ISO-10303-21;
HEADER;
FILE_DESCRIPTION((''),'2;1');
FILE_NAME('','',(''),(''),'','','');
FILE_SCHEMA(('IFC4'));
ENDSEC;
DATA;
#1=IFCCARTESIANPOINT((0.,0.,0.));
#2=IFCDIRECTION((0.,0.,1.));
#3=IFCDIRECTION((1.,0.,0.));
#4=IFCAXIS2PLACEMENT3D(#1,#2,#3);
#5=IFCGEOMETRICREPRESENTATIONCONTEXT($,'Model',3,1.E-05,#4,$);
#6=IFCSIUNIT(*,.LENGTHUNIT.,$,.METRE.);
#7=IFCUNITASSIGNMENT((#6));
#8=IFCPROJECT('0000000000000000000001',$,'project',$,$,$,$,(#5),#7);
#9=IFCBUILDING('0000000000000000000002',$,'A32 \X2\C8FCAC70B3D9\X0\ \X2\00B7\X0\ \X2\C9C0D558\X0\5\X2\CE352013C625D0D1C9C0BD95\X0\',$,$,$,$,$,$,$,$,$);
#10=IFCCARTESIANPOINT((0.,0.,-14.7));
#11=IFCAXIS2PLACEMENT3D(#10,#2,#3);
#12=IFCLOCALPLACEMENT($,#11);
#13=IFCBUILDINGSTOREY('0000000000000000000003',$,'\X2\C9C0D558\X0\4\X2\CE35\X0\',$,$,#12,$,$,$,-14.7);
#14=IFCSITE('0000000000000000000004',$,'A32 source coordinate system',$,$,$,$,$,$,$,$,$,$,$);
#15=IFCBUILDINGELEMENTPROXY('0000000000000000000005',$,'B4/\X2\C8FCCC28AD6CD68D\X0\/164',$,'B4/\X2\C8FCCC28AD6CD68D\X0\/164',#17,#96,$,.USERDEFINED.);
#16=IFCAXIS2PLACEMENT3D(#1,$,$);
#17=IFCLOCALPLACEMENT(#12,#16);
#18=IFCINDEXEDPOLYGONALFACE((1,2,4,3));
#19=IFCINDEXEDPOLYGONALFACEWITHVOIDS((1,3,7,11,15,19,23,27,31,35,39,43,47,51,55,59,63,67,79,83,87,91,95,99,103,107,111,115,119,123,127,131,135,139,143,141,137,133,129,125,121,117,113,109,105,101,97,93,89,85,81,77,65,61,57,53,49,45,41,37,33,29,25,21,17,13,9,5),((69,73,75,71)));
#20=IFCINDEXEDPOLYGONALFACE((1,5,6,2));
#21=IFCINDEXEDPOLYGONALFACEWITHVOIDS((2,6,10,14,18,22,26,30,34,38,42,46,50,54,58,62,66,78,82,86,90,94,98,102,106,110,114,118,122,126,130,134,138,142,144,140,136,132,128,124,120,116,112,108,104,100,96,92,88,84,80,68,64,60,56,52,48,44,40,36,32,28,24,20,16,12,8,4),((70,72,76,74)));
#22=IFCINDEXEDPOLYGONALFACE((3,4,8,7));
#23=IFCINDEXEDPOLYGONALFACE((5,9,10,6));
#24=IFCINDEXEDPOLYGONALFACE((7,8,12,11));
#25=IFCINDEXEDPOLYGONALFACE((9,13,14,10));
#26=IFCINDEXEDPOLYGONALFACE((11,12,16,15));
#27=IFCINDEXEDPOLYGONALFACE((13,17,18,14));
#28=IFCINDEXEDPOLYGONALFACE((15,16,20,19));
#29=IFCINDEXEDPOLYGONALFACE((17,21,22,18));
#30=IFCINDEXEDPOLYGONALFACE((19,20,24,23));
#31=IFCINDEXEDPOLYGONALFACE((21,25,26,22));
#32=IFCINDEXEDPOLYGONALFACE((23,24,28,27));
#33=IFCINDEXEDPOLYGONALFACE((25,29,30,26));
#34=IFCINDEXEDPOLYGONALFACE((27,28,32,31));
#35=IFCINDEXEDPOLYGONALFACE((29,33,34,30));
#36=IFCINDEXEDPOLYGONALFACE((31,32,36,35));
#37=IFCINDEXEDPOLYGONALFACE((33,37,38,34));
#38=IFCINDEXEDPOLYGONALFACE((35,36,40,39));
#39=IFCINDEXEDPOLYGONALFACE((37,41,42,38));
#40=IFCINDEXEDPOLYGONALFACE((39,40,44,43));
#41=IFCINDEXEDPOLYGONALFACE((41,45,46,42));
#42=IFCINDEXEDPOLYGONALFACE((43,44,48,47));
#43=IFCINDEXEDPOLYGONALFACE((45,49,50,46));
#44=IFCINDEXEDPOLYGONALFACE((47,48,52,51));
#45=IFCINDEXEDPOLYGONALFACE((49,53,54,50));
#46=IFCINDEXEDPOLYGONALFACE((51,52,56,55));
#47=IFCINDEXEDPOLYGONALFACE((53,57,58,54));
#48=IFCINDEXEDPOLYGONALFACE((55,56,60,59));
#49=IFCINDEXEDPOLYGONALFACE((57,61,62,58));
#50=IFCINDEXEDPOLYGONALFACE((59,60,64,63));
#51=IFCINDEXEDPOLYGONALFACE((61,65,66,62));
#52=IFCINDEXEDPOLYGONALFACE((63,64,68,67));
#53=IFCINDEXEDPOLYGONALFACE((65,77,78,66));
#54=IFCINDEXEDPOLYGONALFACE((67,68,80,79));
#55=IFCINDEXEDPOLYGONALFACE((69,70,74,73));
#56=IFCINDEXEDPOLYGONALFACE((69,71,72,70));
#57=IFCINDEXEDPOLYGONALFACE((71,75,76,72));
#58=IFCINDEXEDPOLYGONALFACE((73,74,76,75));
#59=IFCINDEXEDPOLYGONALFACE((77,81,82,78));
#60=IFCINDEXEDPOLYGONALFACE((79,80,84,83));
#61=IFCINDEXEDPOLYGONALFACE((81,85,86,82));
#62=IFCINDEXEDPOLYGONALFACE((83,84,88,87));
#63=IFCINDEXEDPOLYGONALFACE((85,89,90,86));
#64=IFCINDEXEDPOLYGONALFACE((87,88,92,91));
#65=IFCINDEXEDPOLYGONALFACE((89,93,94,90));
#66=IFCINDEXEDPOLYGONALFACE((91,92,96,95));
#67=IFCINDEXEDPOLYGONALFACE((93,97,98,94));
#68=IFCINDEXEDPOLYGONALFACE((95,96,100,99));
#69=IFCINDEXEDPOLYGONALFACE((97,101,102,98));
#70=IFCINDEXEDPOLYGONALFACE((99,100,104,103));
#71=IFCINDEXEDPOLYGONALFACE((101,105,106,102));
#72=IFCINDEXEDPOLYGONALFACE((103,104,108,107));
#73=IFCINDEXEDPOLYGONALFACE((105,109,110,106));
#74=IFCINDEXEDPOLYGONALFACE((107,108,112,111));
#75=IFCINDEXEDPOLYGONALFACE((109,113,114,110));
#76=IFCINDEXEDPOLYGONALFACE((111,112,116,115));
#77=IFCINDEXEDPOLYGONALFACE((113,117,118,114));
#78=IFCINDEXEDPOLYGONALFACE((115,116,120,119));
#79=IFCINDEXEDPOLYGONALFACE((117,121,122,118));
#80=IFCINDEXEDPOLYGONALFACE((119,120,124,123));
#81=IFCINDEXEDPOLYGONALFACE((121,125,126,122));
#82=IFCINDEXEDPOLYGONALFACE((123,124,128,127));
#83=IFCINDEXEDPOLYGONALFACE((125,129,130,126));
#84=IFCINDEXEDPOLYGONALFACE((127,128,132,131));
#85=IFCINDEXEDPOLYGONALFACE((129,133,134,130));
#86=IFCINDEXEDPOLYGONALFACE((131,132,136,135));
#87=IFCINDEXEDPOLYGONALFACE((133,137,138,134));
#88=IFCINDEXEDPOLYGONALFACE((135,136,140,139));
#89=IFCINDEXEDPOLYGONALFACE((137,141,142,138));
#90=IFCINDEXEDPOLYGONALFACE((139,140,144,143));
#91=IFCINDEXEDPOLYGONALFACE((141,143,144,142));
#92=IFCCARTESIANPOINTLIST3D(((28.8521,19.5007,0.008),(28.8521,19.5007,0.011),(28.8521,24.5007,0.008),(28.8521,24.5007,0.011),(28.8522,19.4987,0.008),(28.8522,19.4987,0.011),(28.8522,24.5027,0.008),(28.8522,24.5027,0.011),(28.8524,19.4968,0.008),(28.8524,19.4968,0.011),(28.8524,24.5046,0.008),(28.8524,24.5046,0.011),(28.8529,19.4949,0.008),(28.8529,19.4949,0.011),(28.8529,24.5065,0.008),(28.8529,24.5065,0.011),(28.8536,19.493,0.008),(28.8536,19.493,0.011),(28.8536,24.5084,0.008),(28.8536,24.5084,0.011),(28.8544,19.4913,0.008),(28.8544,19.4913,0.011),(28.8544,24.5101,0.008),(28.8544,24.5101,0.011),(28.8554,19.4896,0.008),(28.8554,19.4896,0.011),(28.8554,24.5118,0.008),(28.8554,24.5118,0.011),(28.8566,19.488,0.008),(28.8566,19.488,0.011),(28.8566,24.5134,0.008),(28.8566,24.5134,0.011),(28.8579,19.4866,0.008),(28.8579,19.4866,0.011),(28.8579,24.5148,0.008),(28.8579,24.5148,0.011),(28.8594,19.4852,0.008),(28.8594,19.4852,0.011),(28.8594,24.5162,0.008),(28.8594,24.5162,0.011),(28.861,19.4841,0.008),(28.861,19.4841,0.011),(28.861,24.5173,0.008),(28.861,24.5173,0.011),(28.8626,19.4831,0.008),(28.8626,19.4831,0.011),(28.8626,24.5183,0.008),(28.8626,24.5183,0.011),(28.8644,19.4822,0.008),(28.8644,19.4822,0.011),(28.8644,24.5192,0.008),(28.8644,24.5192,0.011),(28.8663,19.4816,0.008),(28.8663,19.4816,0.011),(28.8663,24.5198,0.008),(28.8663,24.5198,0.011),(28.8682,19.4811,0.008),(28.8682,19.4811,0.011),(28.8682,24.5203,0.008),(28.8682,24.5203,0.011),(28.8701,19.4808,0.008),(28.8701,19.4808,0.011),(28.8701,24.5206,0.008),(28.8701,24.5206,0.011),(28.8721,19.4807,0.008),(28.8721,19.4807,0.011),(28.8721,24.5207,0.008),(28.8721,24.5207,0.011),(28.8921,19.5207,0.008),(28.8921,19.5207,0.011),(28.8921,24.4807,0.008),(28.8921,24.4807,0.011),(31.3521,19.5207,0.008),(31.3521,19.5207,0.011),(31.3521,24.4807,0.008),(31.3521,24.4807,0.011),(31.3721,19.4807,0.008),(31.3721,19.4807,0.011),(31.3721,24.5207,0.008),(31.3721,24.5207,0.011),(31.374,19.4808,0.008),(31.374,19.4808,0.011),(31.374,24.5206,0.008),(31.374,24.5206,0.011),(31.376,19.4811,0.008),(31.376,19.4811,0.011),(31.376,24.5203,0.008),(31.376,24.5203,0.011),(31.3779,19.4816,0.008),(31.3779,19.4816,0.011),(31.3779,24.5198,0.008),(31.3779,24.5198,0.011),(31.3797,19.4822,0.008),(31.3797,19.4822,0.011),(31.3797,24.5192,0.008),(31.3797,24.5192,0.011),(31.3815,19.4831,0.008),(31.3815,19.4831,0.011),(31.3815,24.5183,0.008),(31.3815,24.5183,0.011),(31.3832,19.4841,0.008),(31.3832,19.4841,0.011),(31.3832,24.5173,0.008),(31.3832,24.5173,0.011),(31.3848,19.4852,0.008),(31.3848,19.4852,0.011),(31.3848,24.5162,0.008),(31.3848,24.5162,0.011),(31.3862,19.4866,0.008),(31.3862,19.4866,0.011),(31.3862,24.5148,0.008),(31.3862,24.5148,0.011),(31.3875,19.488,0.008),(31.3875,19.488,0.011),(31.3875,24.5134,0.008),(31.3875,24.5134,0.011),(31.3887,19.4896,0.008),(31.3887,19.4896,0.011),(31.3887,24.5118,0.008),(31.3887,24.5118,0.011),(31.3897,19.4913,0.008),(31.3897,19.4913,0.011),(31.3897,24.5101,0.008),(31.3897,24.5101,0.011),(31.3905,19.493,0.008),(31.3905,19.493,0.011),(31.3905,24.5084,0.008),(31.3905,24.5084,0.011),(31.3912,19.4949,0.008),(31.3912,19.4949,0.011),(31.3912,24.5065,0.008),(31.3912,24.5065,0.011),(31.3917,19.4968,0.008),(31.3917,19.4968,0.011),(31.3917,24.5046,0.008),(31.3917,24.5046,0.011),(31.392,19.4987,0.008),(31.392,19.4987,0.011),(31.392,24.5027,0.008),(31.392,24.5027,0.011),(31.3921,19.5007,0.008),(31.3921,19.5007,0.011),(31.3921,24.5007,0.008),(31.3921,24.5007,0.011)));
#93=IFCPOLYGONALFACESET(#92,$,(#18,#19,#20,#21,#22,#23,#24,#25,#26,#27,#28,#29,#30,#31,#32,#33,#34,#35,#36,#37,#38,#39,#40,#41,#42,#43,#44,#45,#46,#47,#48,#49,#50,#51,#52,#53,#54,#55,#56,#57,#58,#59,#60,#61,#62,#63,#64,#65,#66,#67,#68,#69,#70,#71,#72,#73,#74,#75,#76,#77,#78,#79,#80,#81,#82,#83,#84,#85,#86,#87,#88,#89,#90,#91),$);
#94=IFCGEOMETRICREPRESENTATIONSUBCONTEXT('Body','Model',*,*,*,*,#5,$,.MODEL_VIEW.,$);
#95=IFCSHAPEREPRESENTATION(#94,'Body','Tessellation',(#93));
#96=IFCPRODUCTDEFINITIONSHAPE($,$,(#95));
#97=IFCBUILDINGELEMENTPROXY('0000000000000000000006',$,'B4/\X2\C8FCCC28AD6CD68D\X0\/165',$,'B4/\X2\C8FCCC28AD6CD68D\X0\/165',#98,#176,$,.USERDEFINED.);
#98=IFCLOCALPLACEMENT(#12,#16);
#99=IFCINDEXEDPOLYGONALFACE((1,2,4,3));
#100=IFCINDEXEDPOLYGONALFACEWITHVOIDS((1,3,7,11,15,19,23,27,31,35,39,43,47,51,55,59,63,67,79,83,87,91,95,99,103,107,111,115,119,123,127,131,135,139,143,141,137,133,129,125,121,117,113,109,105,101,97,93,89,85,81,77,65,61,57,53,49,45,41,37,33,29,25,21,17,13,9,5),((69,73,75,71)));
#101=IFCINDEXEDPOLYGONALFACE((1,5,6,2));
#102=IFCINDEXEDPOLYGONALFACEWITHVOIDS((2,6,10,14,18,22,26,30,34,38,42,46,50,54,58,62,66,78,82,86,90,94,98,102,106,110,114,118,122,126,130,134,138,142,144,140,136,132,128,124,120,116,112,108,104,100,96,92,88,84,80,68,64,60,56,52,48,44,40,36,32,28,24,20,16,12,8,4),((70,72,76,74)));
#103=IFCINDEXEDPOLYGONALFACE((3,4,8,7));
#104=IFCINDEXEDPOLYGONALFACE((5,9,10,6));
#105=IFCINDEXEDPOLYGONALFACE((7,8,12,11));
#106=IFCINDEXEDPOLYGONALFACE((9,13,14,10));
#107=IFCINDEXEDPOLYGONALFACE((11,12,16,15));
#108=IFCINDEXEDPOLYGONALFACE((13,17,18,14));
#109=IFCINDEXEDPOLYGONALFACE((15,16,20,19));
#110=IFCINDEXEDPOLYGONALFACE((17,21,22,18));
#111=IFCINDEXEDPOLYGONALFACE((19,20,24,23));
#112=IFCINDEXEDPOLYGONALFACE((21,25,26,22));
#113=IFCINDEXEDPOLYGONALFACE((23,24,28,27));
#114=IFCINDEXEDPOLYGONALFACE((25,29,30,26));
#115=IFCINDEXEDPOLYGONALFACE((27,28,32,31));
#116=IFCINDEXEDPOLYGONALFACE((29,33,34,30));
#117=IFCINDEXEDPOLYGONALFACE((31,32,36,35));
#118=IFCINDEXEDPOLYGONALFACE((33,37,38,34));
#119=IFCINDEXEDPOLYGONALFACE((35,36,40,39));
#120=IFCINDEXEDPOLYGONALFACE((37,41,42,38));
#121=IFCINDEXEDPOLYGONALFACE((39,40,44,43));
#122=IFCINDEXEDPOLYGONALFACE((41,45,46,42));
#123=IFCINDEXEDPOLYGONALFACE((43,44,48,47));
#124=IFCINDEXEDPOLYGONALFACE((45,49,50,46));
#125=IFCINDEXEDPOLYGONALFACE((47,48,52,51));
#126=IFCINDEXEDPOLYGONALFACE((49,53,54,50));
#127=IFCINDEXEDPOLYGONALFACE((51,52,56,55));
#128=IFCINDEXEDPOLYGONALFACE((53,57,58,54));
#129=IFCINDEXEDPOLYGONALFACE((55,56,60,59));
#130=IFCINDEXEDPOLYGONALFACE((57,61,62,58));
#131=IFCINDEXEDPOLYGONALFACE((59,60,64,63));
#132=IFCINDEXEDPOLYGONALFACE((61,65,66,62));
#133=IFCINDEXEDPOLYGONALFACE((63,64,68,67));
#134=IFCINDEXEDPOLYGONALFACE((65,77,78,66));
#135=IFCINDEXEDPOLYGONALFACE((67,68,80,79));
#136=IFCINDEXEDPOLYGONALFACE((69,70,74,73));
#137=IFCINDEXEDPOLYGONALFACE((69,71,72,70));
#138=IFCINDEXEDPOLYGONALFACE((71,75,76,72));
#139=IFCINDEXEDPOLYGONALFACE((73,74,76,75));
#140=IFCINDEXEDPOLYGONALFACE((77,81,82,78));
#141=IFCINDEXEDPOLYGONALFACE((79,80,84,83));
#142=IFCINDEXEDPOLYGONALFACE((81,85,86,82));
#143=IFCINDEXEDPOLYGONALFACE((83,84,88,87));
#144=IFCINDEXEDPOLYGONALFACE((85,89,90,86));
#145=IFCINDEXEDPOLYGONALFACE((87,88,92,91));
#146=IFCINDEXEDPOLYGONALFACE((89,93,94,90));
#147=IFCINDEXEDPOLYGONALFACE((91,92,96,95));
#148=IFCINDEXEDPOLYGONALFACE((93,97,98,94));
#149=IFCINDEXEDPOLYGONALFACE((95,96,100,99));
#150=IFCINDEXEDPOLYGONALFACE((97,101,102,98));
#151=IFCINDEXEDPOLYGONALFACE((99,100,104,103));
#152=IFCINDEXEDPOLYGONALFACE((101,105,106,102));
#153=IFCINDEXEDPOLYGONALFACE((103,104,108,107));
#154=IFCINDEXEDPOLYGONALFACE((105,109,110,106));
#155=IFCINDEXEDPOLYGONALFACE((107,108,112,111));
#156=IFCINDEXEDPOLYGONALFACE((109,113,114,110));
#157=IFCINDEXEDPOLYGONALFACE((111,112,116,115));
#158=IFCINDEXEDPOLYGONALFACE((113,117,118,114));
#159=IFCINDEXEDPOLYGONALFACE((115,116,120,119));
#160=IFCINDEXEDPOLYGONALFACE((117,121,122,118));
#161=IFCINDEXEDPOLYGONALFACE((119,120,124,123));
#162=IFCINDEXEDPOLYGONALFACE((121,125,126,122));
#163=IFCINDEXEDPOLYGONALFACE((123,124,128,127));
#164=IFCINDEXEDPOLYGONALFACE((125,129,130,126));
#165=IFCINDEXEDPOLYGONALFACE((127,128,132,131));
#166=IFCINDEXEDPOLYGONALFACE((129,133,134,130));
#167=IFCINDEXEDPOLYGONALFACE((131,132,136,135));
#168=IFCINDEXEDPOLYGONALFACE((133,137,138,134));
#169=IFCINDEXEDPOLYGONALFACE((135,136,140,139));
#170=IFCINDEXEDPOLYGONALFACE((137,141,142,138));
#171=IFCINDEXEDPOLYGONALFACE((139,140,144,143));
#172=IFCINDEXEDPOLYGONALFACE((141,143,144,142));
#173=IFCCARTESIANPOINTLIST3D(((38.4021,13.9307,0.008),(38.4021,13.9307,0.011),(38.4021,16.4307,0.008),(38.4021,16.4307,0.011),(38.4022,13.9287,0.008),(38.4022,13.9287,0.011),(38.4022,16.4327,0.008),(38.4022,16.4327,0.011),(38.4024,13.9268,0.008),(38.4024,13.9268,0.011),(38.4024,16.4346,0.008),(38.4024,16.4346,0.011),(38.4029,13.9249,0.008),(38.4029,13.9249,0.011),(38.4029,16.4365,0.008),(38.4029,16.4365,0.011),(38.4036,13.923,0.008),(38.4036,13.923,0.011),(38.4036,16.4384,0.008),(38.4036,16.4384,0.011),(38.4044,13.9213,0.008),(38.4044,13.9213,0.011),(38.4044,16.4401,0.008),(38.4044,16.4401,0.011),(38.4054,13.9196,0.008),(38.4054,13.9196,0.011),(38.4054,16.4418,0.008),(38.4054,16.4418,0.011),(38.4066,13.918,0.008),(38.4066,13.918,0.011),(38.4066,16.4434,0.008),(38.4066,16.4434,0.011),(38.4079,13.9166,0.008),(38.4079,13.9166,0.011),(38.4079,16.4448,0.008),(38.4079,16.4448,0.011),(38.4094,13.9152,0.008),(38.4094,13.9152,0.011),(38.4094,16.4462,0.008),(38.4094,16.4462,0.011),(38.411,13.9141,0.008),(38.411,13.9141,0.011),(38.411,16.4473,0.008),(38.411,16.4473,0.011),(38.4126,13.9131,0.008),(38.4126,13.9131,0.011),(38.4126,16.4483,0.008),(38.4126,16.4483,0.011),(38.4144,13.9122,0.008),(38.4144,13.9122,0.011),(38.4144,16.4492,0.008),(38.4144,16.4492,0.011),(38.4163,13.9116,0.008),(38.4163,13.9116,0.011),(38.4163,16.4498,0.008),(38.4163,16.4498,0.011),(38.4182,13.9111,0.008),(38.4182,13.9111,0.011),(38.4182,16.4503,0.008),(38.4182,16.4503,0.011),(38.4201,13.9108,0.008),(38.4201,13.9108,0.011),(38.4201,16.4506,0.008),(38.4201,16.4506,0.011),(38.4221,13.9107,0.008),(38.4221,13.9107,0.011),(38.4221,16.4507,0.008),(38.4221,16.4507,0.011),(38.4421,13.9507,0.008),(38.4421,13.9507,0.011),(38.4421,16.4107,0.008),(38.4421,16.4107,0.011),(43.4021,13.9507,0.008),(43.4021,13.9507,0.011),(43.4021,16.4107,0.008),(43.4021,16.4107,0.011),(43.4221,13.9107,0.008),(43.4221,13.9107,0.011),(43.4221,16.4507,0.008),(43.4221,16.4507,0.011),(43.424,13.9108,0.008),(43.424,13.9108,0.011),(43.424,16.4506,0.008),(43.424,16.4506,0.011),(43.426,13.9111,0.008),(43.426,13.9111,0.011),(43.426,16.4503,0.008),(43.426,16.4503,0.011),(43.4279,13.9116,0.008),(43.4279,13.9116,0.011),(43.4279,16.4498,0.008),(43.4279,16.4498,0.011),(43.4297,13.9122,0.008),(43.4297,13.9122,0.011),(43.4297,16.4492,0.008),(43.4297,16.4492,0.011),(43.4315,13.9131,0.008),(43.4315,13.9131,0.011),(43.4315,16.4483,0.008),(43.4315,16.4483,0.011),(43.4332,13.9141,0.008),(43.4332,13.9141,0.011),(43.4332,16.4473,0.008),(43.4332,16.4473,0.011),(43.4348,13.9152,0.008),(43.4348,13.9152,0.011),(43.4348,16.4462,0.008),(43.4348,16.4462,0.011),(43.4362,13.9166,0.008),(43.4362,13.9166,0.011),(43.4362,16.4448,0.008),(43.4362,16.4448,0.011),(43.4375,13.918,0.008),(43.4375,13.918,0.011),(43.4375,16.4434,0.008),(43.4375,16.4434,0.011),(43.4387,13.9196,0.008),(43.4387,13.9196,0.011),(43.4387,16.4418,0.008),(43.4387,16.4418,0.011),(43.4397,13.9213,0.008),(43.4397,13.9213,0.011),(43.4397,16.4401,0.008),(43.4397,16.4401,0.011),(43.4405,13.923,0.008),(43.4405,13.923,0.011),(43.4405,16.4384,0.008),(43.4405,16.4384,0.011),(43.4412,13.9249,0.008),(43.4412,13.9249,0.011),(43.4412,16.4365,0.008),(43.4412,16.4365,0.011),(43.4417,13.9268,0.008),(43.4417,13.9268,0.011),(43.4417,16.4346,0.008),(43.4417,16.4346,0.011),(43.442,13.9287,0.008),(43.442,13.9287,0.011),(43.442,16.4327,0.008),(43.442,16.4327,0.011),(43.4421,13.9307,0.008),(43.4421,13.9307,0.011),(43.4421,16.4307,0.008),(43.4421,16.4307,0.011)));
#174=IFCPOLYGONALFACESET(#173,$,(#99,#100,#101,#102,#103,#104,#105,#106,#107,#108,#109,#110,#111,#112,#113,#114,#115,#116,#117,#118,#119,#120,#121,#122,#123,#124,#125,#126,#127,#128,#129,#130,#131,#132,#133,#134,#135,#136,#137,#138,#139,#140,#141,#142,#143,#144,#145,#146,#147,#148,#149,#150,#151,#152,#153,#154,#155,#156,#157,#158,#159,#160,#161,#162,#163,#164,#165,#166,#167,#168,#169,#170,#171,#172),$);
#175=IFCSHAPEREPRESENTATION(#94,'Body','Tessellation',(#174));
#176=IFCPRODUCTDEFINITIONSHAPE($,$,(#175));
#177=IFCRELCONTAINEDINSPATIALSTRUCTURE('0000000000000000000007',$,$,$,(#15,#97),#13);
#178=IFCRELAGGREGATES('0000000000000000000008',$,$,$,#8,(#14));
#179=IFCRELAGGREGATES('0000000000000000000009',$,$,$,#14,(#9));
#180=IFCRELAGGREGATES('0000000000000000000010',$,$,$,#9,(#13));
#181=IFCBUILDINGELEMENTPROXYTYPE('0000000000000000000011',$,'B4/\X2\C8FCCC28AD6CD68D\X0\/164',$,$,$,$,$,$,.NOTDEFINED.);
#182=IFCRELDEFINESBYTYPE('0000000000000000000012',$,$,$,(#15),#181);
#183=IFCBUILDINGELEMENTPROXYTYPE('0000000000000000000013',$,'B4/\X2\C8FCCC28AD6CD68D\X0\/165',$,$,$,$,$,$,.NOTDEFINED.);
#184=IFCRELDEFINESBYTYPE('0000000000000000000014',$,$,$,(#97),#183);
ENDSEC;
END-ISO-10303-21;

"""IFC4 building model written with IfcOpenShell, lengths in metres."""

from ifc_helpers import new_model, si_unit, frame, origin, origin_with_axes, place, context, subcontext, project, spatial, polyline, outline, extrude, source, transform, mapped, type_object, type_shapes, element, save


model = new_model("IFC4")

# Units and contexts
model_context = context("Model", 3, precision=1e-05, world=origin_with_axes())
body_context = subcontext(model_context, "Body", "Model", "MODEL_VIEW")
ifc_project = project(units=[si_unit("LENGTHUNIT", "METRE")], contexts=[model_context])

# Site, building, storey
site = spatial("IfcSite", under=ifc_project, Name="A32 source coordinate system")
building = spatial("IfcBuilding", under=site, Name="A32 주거동 · 지하5층–옥탑지붕")
storey_placement = place(None, frame((0.0, 0.0, -14.7), z_axis=(0.0, 0.0, 1.0), x_axis=(1.0, 0.0, 0.0)))
storey = spatial("IfcBuildingStorey", under=building, at=storey_placement, Name="지하4층", Elevation=-14.7)

# Building element proxies
building_element_proxy_type_1 = type_object("IfcBuildingElementProxyType", Name="B4/주차구획/164", PredefinedType="NOTDEFINED")
shared_shape_1 = source(origin(), body_context, "Body", "SweptSolid", [
    extrude(outline(polyline([(31.3921, 19.5007), (31.392, 19.4987), (31.3917, 19.4968), (31.3912, 19.4949), (31.3905, 19.493), (31.3897, 19.4913), (31.3887, 19.4896), (31.3875, 19.488), (31.3862, 19.4866), (31.3848, 19.4852), (31.3832, 19.4841), (31.3815, 19.4831), (31.3797, 19.4822), (31.3779, 19.4816), (31.376, 19.4811), (31.374, 19.4808), (31.3721, 19.4807), (28.8721, 19.4807), (28.8701, 19.4808), (28.8682, 19.4811), (28.8663, 19.4816), (28.8644, 19.4822), (28.8626, 19.4831), (28.861, 19.4841), (28.8594, 19.4852), (28.8579, 19.4866), (28.8566, 19.488), (28.8554, 19.4896), (28.8544, 19.4913), (28.8536, 19.493), (28.8529, 19.4949), (28.8524, 19.4968), (28.8522, 19.4987), (28.8521, 19.5007), (28.8521, 24.5007), (28.8522, 24.5027), (28.8524, 24.5046), (28.8529, 24.5065), (28.8536, 24.5084), (28.8544, 24.5101), (28.8554, 24.5118), (28.8566, 24.5134), (28.8579, 24.5148), (28.8594, 24.5162), (28.861, 24.5173), (28.8626, 24.5183), (28.8644, 24.5192), (28.8663, 24.5198), (28.8682, 24.5203), (28.8701, 24.5206), (28.8721, 24.5207), (31.3721, 24.5207), (31.374, 24.5206), (31.376, 24.5203), (31.3779, 24.5198), (31.3797, 24.5192), (31.3815, 24.5183), (31.3832, 24.5173), (31.3848, 24.5162), (31.3862, 24.5148), (31.3875, 24.5134), (31.3887, 24.5118), (31.3897, 24.5101), (31.3905, 24.5084), (31.3912, 24.5065), (31.3917, 24.5046), (31.392, 24.5027), (31.3921, 24.5007), (31.3921, 19.5007)]), holes=[polyline([(31.3521, 19.5207), (31.3521, 24.4807), (28.8921, 24.4807), (28.8921, 19.5207), (31.3521, 19.5207)])]), frame((0.0, 0.0, 0.008)), (0.0, 0.0, 1.0), 0.003),
])
type_shapes(building_element_proxy_type_1, [shared_shape_1])
proxy_1_placement = place(storey_placement, origin_with_axes())
element("IfcBuildingElementProxy", 1, at=proxy_1_placement, inside=storey, type_object=building_element_proxy_type_1, Name="B4/주차구획/164", ObjectType="B4/주차구획/164", PredefinedType="USERDEFINED", context=body_context, shape_type="MappedRepresentation", body=[
    mapped(shared_shape_1, transform((0.0, 0.0, 0.0), scale=1.0)),
])
building_element_proxy_type_2 = type_object("IfcBuildingElementProxyType", Name="B4/주차구획/165", PredefinedType="NOTDEFINED")
shared_shape_2 = source(origin(), body_context, "Body", "SweptSolid", [
    extrude(outline(polyline([(43.4221, 16.4507), (43.424, 16.4506), (43.426, 16.4503), (43.4279, 16.4498), (43.4297, 16.4492), (43.4315, 16.4483), (43.4332, 16.4473), (43.4348, 16.4462), (43.4362, 16.4448), (43.4375, 16.4434), (43.4387, 16.4418), (43.4397, 16.4401), (43.4405, 16.4384), (43.4412, 16.4365), (43.4417, 16.4346), (43.442, 16.4327), (43.4421, 16.4307), (43.4421, 13.9307), (43.442, 13.9287), (43.4417, 13.9268), (43.4412, 13.9249), (43.4405, 13.923), (43.4397, 13.9213), (43.4387, 13.9196), (43.4375, 13.918), (43.4362, 13.9166), (43.4348, 13.9152), (43.4332, 13.9141), (43.4315, 13.9131), (43.4297, 13.9122), (43.4279, 13.9116), (43.426, 13.9111), (43.424, 13.9108), (43.4221, 13.9107), (38.4221, 13.9107), (38.4201, 13.9108), (38.4182, 13.9111), (38.4163, 13.9116), (38.4144, 13.9122), (38.4126, 13.9131), (38.411, 13.9141), (38.4094, 13.9152), (38.4079, 13.9166), (38.4066, 13.918), (38.4054, 13.9196), (38.4044, 13.9213), (38.4036, 13.923), (38.4029, 13.9249), (38.4024, 13.9268), (38.4022, 13.9287), (38.4021, 13.9307), (38.4021, 16.4307), (38.4022, 16.4327), (38.4024, 16.4346), (38.4029, 16.4365), (38.4036, 16.4384), (38.4044, 16.4401), (38.4054, 16.4418), (38.4066, 16.4434), (38.4079, 16.4448), (38.4094, 16.4462), (38.411, 16.4473), (38.4126, 16.4483), (38.4144, 16.4492), (38.4163, 16.4498), (38.4182, 16.4503), (38.4201, 16.4506), (38.4221, 16.4507), (43.4221, 16.4507)]), holes=[polyline([(43.4021, 16.4107), (38.4421, 16.4107), (38.4421, 13.9507), (43.4021, 13.9507), (43.4021, 16.4107)])]), frame((0.0, 0.0, 0.008)), (0.0, 0.0, 1.0), 0.003),
])
type_shapes(building_element_proxy_type_2, [shared_shape_2])
proxy_2_placement = place(storey_placement, origin_with_axes())
element("IfcBuildingElementProxy", 2, at=proxy_2_placement, inside=storey, type_object=building_element_proxy_type_2, Name="B4/주차구획/165", ObjectType="B4/주차구획/165", PredefinedType="USERDEFINED", context=body_context, shape_type="MappedRepresentation", body=[
    mapped(shared_shape_2, transform((0.0, 0.0, 0.0), scale=1.0)),
])

save(model, "model.ifc")
